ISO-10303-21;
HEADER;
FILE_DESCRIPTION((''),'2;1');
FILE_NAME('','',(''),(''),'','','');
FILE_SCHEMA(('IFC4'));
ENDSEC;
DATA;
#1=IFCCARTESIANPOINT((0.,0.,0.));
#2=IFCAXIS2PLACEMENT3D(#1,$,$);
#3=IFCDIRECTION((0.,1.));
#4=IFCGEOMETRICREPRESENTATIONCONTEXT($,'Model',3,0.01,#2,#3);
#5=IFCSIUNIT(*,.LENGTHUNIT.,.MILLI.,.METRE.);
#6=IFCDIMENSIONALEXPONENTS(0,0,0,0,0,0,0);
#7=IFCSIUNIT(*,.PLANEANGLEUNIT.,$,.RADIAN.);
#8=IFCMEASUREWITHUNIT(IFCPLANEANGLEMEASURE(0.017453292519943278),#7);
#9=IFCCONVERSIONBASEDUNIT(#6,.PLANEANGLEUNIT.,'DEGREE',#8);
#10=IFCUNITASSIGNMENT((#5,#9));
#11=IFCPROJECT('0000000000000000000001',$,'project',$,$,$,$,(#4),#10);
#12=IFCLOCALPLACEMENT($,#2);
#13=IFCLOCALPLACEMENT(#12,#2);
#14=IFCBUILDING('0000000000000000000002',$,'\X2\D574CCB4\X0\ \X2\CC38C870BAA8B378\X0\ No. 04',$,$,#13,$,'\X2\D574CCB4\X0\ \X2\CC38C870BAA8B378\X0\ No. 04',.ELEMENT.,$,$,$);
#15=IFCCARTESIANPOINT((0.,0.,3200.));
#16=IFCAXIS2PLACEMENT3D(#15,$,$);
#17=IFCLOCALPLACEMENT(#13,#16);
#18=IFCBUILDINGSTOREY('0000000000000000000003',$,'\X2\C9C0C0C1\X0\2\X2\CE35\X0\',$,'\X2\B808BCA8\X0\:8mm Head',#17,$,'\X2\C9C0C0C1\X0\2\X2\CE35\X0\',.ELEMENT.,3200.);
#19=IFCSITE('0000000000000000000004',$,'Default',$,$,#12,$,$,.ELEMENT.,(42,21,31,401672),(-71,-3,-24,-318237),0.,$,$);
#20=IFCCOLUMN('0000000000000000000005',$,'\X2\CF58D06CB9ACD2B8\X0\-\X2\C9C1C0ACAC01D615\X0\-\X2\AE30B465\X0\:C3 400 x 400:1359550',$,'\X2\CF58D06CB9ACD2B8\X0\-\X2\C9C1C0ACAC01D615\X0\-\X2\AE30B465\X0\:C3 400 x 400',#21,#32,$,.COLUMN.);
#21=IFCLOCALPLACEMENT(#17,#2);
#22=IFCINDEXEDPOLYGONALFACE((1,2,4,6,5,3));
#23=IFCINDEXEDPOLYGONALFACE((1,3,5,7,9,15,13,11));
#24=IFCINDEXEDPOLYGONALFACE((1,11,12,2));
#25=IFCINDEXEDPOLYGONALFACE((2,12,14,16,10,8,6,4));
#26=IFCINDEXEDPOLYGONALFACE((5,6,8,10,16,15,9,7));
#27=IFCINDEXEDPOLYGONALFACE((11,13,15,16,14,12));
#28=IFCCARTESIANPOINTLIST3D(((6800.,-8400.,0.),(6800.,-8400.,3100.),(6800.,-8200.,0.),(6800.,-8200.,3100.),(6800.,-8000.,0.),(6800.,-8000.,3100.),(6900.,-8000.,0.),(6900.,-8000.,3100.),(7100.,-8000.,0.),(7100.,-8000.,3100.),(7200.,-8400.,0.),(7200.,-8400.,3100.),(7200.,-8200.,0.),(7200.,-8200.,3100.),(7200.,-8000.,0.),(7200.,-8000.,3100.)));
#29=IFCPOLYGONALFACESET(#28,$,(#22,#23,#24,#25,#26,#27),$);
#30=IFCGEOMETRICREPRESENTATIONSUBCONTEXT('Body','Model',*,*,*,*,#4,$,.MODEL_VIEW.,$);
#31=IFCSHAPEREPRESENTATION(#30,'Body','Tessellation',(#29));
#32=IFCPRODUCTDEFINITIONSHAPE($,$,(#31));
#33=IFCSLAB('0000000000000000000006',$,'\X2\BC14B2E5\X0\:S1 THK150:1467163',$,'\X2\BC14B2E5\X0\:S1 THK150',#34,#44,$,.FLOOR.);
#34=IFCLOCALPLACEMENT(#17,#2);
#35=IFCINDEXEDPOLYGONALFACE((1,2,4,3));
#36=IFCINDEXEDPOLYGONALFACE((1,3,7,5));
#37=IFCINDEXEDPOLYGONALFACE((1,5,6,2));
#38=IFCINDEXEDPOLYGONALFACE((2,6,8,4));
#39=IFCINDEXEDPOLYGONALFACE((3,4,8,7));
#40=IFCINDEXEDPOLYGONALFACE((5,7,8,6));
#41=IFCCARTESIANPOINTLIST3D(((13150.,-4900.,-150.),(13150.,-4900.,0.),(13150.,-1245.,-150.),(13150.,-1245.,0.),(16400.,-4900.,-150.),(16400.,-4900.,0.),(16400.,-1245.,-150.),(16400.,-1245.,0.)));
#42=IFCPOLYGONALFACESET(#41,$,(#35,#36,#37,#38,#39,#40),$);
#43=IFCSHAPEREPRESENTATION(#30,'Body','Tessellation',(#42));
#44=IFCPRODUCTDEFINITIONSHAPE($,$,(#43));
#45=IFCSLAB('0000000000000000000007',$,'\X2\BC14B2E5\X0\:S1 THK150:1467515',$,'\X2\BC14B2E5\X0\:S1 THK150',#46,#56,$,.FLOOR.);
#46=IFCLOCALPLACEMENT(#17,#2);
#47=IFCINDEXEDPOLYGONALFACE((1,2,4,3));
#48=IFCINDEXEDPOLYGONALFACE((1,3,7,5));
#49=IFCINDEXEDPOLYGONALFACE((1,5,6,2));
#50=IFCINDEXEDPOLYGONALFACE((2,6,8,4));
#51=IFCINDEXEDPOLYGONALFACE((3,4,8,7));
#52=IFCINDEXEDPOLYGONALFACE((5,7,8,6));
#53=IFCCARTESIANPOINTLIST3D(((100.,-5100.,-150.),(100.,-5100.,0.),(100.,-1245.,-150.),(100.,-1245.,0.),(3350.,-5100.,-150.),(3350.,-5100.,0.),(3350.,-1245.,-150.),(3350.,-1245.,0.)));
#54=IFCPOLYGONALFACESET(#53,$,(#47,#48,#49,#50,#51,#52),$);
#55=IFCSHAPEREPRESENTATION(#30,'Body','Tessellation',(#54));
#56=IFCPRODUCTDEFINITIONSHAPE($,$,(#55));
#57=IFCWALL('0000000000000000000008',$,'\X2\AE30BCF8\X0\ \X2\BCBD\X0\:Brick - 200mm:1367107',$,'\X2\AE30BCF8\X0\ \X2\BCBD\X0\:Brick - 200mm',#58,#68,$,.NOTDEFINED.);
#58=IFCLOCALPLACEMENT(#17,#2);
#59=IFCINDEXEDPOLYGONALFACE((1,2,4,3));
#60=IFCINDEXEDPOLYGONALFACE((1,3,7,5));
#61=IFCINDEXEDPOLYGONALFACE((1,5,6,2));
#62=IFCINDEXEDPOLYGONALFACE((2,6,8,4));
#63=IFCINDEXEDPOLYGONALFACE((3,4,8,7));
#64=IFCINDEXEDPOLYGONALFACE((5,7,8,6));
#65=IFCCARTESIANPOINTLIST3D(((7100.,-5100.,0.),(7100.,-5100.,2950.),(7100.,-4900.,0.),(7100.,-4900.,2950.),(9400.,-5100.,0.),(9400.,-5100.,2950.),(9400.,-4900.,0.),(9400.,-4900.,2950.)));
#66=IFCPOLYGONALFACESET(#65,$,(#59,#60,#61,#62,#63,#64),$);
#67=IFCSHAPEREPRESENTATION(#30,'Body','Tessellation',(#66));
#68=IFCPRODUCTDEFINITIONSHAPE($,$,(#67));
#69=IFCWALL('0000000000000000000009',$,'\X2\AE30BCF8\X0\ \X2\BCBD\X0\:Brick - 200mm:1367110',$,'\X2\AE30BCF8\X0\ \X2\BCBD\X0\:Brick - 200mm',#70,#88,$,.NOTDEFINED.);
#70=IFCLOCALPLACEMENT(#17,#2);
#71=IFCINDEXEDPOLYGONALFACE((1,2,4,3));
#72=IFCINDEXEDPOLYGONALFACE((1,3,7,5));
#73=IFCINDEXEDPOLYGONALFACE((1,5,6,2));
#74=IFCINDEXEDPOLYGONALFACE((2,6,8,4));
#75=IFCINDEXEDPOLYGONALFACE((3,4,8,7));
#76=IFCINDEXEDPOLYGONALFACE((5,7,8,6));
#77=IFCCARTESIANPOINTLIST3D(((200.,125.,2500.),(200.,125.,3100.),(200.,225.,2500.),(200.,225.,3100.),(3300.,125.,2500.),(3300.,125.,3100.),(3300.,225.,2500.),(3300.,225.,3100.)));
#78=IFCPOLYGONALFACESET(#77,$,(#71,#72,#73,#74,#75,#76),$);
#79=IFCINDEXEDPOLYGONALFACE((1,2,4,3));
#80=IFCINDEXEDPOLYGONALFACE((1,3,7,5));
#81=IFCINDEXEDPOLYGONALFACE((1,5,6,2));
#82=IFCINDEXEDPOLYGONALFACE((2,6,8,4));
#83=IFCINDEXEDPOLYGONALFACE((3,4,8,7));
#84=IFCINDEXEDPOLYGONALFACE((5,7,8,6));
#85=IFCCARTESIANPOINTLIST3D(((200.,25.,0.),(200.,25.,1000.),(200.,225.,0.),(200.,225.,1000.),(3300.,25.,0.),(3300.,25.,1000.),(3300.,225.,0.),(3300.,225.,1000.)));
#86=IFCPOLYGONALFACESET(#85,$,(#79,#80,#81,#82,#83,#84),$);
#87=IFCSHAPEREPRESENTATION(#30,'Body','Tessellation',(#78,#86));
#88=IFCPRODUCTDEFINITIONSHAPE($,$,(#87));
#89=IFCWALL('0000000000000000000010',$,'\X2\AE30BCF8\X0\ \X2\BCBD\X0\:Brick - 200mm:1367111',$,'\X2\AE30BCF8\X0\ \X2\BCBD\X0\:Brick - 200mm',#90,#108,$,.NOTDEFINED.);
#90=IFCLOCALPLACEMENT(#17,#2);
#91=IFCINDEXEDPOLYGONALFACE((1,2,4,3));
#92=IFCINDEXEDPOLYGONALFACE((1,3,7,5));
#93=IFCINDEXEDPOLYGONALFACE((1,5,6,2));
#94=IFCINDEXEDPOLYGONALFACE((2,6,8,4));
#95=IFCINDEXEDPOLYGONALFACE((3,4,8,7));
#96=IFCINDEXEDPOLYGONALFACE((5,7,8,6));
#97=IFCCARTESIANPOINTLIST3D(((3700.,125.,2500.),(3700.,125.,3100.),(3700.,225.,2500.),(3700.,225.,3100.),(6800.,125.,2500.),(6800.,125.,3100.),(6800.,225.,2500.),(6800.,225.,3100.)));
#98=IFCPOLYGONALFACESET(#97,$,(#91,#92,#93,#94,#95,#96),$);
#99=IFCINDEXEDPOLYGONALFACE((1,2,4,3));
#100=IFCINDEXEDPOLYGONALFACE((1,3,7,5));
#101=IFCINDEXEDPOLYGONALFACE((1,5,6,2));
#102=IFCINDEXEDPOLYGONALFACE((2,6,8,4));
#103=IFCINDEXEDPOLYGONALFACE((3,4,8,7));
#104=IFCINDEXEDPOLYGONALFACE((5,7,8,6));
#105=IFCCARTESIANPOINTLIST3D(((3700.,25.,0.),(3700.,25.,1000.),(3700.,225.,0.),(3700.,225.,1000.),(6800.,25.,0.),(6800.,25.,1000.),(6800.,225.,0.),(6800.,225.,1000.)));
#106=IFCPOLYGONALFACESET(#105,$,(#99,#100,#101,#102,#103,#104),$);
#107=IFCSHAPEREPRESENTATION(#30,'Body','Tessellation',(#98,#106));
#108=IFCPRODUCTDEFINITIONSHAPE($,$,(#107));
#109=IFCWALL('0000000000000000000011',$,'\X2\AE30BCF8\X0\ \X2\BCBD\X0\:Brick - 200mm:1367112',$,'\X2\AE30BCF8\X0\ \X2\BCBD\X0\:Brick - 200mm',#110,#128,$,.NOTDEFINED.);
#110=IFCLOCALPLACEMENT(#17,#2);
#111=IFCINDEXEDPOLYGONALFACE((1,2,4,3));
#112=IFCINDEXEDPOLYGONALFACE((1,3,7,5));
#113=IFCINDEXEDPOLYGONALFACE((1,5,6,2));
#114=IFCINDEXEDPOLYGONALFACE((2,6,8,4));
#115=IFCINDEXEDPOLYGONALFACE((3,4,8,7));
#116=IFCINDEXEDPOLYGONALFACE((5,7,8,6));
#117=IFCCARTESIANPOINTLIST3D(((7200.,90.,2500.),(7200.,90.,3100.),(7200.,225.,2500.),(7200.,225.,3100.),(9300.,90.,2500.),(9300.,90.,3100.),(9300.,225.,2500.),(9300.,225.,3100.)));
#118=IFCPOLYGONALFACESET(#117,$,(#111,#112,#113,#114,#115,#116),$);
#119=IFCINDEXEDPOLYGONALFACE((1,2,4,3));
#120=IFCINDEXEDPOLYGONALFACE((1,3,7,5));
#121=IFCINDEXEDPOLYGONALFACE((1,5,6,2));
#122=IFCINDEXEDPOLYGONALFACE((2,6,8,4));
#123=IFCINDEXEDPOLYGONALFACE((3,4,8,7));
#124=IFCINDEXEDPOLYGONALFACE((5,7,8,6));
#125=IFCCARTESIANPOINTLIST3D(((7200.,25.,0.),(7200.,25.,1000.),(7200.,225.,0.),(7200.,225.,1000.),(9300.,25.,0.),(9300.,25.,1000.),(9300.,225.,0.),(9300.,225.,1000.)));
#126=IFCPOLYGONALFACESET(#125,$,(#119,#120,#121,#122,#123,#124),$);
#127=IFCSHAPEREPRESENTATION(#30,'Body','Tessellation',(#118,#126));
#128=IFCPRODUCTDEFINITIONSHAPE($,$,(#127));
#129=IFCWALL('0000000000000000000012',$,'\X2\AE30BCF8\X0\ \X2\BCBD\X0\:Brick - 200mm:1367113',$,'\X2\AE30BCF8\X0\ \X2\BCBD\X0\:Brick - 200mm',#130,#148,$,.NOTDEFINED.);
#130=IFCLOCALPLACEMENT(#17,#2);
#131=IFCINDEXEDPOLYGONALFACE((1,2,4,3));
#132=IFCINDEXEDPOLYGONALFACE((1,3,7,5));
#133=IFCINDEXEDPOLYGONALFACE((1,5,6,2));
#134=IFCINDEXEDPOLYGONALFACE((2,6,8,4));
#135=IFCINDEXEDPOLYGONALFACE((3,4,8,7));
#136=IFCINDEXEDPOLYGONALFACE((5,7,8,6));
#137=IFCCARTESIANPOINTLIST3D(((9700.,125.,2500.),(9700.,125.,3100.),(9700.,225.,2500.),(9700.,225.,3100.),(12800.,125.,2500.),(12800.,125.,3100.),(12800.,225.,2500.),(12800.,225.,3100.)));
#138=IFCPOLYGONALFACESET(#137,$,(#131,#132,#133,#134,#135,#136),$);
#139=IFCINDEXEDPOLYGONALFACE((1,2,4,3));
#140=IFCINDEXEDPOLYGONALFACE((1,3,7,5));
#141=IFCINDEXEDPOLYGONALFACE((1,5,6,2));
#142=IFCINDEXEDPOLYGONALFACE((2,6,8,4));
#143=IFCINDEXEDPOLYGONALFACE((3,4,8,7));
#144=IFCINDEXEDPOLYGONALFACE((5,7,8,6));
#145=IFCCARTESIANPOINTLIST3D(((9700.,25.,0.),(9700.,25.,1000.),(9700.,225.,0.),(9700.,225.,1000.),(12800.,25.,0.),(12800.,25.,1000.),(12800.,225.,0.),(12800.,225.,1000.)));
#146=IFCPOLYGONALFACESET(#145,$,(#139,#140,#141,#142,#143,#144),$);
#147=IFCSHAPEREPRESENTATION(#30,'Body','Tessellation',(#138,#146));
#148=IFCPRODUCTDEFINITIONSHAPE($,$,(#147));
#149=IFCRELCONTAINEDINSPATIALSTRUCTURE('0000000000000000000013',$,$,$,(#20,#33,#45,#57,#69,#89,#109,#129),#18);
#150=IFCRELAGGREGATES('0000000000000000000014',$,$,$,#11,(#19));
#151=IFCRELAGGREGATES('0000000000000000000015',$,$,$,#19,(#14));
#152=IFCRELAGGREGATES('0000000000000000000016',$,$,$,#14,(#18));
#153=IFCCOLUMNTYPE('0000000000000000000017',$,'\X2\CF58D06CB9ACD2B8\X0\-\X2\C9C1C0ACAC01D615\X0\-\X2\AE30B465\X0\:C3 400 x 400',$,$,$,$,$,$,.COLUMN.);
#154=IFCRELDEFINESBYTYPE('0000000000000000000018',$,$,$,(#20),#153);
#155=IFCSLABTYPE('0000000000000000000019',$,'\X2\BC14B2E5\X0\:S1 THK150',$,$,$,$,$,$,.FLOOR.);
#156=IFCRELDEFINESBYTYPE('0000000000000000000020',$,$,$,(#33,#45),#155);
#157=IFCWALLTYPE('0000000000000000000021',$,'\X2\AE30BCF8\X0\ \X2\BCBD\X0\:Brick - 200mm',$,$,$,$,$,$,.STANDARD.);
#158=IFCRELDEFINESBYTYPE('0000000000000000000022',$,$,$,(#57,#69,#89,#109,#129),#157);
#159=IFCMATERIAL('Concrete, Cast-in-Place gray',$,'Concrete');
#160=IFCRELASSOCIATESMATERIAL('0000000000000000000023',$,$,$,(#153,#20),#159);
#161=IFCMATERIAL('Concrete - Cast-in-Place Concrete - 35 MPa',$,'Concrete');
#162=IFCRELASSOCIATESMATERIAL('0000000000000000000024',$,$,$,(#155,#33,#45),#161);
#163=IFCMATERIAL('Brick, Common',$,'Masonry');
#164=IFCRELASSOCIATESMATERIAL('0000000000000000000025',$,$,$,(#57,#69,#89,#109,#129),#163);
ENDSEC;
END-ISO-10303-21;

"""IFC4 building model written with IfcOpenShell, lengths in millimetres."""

from ifc_helpers import new_model, entity, si_unit, converted_unit, direction, frame, origin, place, context, subcontext, project, spatial, indexed_curve, outline, extrude, source, transform, mapped, material, type_object, type_shapes, element, save


model = new_model("IFC4")

# Units and contexts
model_context = context("Model", 3, precision=0.01, world=origin(), true_north=direction((0.0, 1.0)))
body_context = subcontext(model_context, "Body", "Model", "MODEL_VIEW")
ifc_project = project(units=[si_unit("LENGTHUNIT", "METRE", prefix="MILLI"), converted_unit("PLANEANGLEUNIT", "DEGREE", entity("IfcPlaneAngleMeasure", 0.017453292519943278), si_unit("PLANEANGLEUNIT", "RADIAN"), dimensions=[0, 0, 0, 0, 0, 0, 0])], contexts=[model_context])

# Site, building, storey
site_placement = place(None, origin())
site = spatial("IfcSite", under=ifc_project, at=site_placement, Name="Default", CompositionType="ELEMENT", RefLatitude=(42, 21, 31, 401672), RefLongitude=(-71, -3, -24, -318237), RefElevation=0.0)
building_placement = place(site_placement, origin())
building = spatial("IfcBuilding", under=site, at=building_placement, Name="해체 참조모델 No. 04", LongName="해체 참조모델 No. 04", CompositionType="ELEMENT")
storey_placement = place(building_placement, frame((0.0, 0.0, 3200.0)))
storey = spatial("IfcBuildingStorey", under=building, at=storey_placement, Name="지상2층", ObjectType="레벨:8mm Head", LongName="지상2층", CompositionType="ELEMENT", Elevation=3200.0)

# Column
ifc_material_1 = material(Name="Concrete, Cast-in-Place gray", Category="Concrete")
column_type_1 = type_object("IfcColumnType", Name="콘크리트-직사각형-기둥:C3 400 x 400", PredefinedType="COLUMN", material=ifc_material_1)
shared_shape_1 = source(origin(), body_context, "Body", "SweptSolid", [
    extrude(outline(indexed_curve([(-200.0, -150.0), (-100.0, -150.0), (100.0, -150.0), (200.0, -150.0), (200.0, 50.0), (200.0, 250.0), (-200.0, 250.0), (-200.0, 50.0), (-200.0, -150.0)], self_intersect=False)), frame((7000.0, -8150.0, 3200.0), z_axis=(0.0, 0.0, 1.0), x_axis=(-1.0, 0.0, 0.0)), (0.0, 0.0, 1.0), 3100.0),
])
type_shapes(column_type_1, [shared_shape_1])
column_1_placement = place(storey_placement, frame((0.0, 0.0, -3200.0)))
element("IfcColumn", 1, at=column_1_placement, inside=storey, type_object=column_type_1, material=ifc_material_1, Name="콘크리트-직사각형-기둥:C3 400 x 400:1359550", ObjectType="콘크리트-직사각형-기둥:C3 400 x 400", PredefinedType="COLUMN", context=body_context, shape_type="MappedRepresentation", body=[
    mapped(shared_shape_1, transform((0.0, 0.0, 0.0), scale=1.0)),
])

# Slabs
ifc_material_2 = material(Name="Concrete - Cast-in-Place Concrete - 35 MPa", Category="Concrete")
slab_type_1 = type_object("IfcSlabType", Name="바닥:S1 THK150", PredefinedType="FLOOR", material=ifc_material_2)
slab_1_placement = place(storey_placement, origin())
element("IfcSlab", 2, at=slab_1_placement, inside=storey, type_object=slab_type_1, material=ifc_material_2, Name="바닥:S1 THK150:1467163", ObjectType="바닥:S1 THK150", PredefinedType="FLOOR", context=body_context, shape_type="SweptSolid", body=[
    extrude(outline(indexed_curve([(-1827.5, -1625.0), (1827.5, -1625.0), (1827.5, 1625.0), (-1827.5, 1625.0), (-1827.5, -1625.0)], self_intersect=False)), frame((14775.0, -3072.5, 0.0), z_axis=(0.0, 0.0, -1.0), x_axis=(0.0, 1.0, 0.0)), (0.0, 0.0, 1.0), 150.0),
])
slab_2_placement = place(storey_placement, origin())
element("IfcSlab", 3, at=slab_2_placement, inside=storey, type_object=slab_type_1, material=ifc_material_2, Name="바닥:S1 THK150:1467515", ObjectType="바닥:S1 THK150", PredefinedType="FLOOR", context=body_context, shape_type="SweptSolid", body=[
    extrude(outline(indexed_curve([(-1927.5, -1625.0), (1927.5, -1625.0), (1927.5, 1625.0), (-1927.5, 1625.0), (-1927.5, -1625.0)], self_intersect=False)), frame((1725.0, -3172.5, 0.0), z_axis=(0.0, 0.0, -1.0), x_axis=(0.0, 1.0, 0.0)), (0.0, 0.0, 1.0), 150.0),
])

# Wall
ifc_material_3 = material(Name="Brick, Common", Category="Masonry")
wall_type = type_object("IfcWallType", Name="기본 벽:Brick - 200mm", PredefinedType="STANDARD")
wall_1_placement = place(storey_placement, frame((9400.0, -5000.0, 0.0), z_axis=(0.0, 0.0, 1.0), x_axis=(-1.0, 0.0, 0.0)))
element("IfcWall", 4, at=wall_1_placement, inside=storey, type_object=wall_type, material=ifc_material_3, Name="기본 벽:Brick - 200mm:1367107", ObjectType="기본 벽:Brick - 200mm", PredefinedType="NOTDEFINED", context=body_context, shape_type="SweptSolid", body=[
    extrude(outline(indexed_curve([(2300.0, 100.0), (0.0, 100.0), (0.0, -100.0), (2300.0, -100.0), (2300.0, 100.0)], self_intersect=False)), origin(), (0.0, 0.0, 1.0), 2950.0),
])

# Walls, openings
wall_2_placement = place(storey_placement, frame((200.0, 125.0, 0.0)))
wall_2 = element("IfcWall", 5, at=wall_2_placement, inside=storey, type_object=wall_type, material=ifc_material_3, Name="기본 벽:Brick - 200mm:1367110", ObjectType="기본 벽:Brick - 200mm", PredefinedType="NOTDEFINED", context=body_context, shape_type="SweptSolid", body=[
    extrude(outline(indexed_curve([(-50.0, -1550.0), (50.0, -1550.0), (50.0, 1550.0), (-50.0, 1550.0), (-50.0, -1550.0)], self_intersect=False)), frame((1550.0, 50.0, 2500.0), z_axis=(0.0, 0.0, 1.0), x_axis=(0.0, -1.0, 0.0)), (0.0, 0.0, 1.0), 600.0),
    extrude(outline(indexed_curve([(-100.0, -1550.0), (0.0, -1550.0), (100.0, -1550.0), (100.0, 1550.0), (0.0, 1550.0), (-100.0, 1550.0), (-100.0, -1550.0)], self_intersect=False)), frame((1550.0, 0.0, 0.0), z_axis=(0.0, 0.0, 1.0), x_axis=(0.0, 1.0, 0.0)), (0.0, 0.0, 1.0), 1000.0),
])
opening_1_placement = place(wall_2_placement, origin())
element("IfcOpeningElement", 6, at=opening_1_placement, cuts=wall_2, PredefinedType="OPENING", context=body_context, shape_type="SweptSolid", body=[
    extrude(outline(indexed_curve([(-750.0, -1550.0), (750.0, -1550.0), (750.0, 1550.0), (-750.0, 1550.0), (-750.0, -1550.0)], self_intersect=False)), frame((1550.0, -252.4, 1750.0), z_axis=(0.0, 1.0, 0.0), x_axis=(0.0, 0.0, 1.0)), (0.0, 0.0, 1.0), 504.8),
])
wall_3_placement = place(storey_placement, frame((3700.0, 125.0, 0.0)))
wall_3 = element("IfcWall", 7, at=wall_3_placement, inside=storey, type_object=wall_type, material=ifc_material_3, Name="기본 벽:Brick - 200mm:1367111", ObjectType="기본 벽:Brick - 200mm", PredefinedType="NOTDEFINED", context=body_context, shape_type="SweptSolid", body=[
    extrude(outline(indexed_curve([(-50.0, -1550.0), (50.0, -1550.0), (50.0, 1550.0), (-50.0, 1550.0), (-50.0, -1550.0)], self_intersect=False)), frame((1550.0, 50.0, 2500.0), z_axis=(0.0, 0.0, 1.0), x_axis=(0.0, -1.0, 0.0)), (0.0, 0.0, 1.0), 600.0),
    extrude(outline(indexed_curve([(-100.0, -1550.0), (0.0, -1550.0), (100.0, -1550.0), (100.0, 1550.0), (0.0, 1550.0), (-100.0, 1550.0), (-100.0, -1550.0)], self_intersect=False)), frame((1550.0, 0.0, 0.0), z_axis=(0.0, 0.0, 1.0), x_axis=(0.0, 1.0, 0.0)), (0.0, 0.0, 1.0), 1000.0),
])
opening_2_placement = place(wall_3_placement, origin())
element("IfcOpeningElement", 8, at=opening_2_placement, cuts=wall_3, PredefinedType="OPENING", context=body_context, shape_type="SweptSolid", body=[
    extrude(outline(indexed_curve([(-750.0, -1550.0), (750.0, -1550.0), (750.0, 1550.0), (-750.0, 1550.0), (-750.0, -1550.0)], self_intersect=False)), frame((1550.0, -252.4, 1750.0), z_axis=(0.0, 1.0, 0.0), x_axis=(0.0, 0.0, 1.0)), (0.0, 0.0, 1.0), 504.8),
])
wall_4_placement = place(storey_placement, frame((7200.0, 125.0, 0.0)))
wall_4 = element("IfcWall", 9, at=wall_4_placement, inside=storey, type_object=wall_type, material=ifc_material_3, Name="기본 벽:Brick - 200mm:1367112", ObjectType="기본 벽:Brick - 200mm", PredefinedType="NOTDEFINED", context=body_context, shape_type="SweptSolid", body=[
    extrude(outline(indexed_curve([(-67.5, -1050.0), (67.5, -1050.0), (67.5, 1050.0), (-67.5, 1050.0), (-67.5, -1050.0)], self_intersect=False)), frame((1050.0, 32.5, 2500.0), z_axis=(0.0, 0.0, 1.0), x_axis=(0.0, -1.0, 0.0)), (0.0, 0.0, 1.0), 600.0),
    extrude(outline(indexed_curve([(-88.3, -1050.0), (-23.3, -1050.0), (111.7, -1050.0), (111.7, 1050.0), (-23.3, 1050.0), (-88.3, 1050.0), (-88.3, -1050.0)], self_intersect=False)), frame((1050.0, -11.7, 0.0), z_axis=(0.0, 0.0, 1.0), x_axis=(0.0, 1.0, 0.0)), (0.0, 0.0, 1.0), 1000.0),
])
opening_3_placement = place(wall_4_placement, origin())
element("IfcOpeningElement", 10, at=opening_3_placement, cuts=wall_4, PredefinedType="OPENING", context=body_context, shape_type="SweptSolid", body=[
    extrude(outline(indexed_curve([(-750.0, -1050.0), (750.0, -1050.0), (750.0, 1050.0), (-750.0, 1050.0), (-750.0, -1050.0)], self_intersect=False)), frame((1050.0, -252.4, 1750.0), z_axis=(0.0, 1.0, 0.0), x_axis=(0.0, 0.0, 1.0)), (0.0, 0.0, 1.0), 504.8),
])
wall_5_placement = place(storey_placement, frame((9700.0, 125.0, 0.0)))
wall_5 = element("IfcWall", 11, at=wall_5_placement, inside=storey, type_object=wall_type, material=ifc_material_3, Name="기본 벽:Brick - 200mm:1367113", ObjectType="기본 벽:Brick - 200mm", PredefinedType="NOTDEFINED", context=body_context, shape_type="SweptSolid", body=[
    extrude(outline(indexed_curve([(-50.0, -1550.0), (50.0, -1550.0), (50.0, 1550.0), (-50.0, 1550.0), (-50.0, -1550.0)], self_intersect=False)), frame((1550.0, 50.0, 2500.0), z_axis=(0.0, 0.0, 1.0), x_axis=(0.0, -1.0, 0.0)), (0.0, 0.0, 1.0), 600.0),
    extrude(outline(indexed_curve([(-100.0, -1550.0), (0.0, -1550.0), (100.0, -1550.0), (100.0, 1550.0), (0.0, 1550.0), (-100.0, 1550.0), (-100.0, -1550.0)], self_intersect=False)), frame((1550.0, 0.0, 0.0), z_axis=(0.0, 0.0, 1.0), x_axis=(0.0, 1.0, 0.0)), (0.0, 0.0, 1.0), 1000.0),
])
opening_4_placement = place(wall_5_placement, origin())
element("IfcOpeningElement", 12, at=opening_4_placement, cuts=wall_5, PredefinedType="OPENING", context=body_context, shape_type="SweptSolid", body=[
    extrude(outline(indexed_curve([(-750.0, -1550.0), (750.0, -1550.0), (750.0, 1550.0), (-750.0, 1550.0), (-750.0, -1550.0)], self_intersect=False)), frame((1550.0, -252.4, 1750.0), z_axis=(0.0, 1.0, 0.0), x_axis=(0.0, 0.0, 1.0)), (0.0, 0.0, 1.0), 504.8),
])

save(model, "model.ifc")
